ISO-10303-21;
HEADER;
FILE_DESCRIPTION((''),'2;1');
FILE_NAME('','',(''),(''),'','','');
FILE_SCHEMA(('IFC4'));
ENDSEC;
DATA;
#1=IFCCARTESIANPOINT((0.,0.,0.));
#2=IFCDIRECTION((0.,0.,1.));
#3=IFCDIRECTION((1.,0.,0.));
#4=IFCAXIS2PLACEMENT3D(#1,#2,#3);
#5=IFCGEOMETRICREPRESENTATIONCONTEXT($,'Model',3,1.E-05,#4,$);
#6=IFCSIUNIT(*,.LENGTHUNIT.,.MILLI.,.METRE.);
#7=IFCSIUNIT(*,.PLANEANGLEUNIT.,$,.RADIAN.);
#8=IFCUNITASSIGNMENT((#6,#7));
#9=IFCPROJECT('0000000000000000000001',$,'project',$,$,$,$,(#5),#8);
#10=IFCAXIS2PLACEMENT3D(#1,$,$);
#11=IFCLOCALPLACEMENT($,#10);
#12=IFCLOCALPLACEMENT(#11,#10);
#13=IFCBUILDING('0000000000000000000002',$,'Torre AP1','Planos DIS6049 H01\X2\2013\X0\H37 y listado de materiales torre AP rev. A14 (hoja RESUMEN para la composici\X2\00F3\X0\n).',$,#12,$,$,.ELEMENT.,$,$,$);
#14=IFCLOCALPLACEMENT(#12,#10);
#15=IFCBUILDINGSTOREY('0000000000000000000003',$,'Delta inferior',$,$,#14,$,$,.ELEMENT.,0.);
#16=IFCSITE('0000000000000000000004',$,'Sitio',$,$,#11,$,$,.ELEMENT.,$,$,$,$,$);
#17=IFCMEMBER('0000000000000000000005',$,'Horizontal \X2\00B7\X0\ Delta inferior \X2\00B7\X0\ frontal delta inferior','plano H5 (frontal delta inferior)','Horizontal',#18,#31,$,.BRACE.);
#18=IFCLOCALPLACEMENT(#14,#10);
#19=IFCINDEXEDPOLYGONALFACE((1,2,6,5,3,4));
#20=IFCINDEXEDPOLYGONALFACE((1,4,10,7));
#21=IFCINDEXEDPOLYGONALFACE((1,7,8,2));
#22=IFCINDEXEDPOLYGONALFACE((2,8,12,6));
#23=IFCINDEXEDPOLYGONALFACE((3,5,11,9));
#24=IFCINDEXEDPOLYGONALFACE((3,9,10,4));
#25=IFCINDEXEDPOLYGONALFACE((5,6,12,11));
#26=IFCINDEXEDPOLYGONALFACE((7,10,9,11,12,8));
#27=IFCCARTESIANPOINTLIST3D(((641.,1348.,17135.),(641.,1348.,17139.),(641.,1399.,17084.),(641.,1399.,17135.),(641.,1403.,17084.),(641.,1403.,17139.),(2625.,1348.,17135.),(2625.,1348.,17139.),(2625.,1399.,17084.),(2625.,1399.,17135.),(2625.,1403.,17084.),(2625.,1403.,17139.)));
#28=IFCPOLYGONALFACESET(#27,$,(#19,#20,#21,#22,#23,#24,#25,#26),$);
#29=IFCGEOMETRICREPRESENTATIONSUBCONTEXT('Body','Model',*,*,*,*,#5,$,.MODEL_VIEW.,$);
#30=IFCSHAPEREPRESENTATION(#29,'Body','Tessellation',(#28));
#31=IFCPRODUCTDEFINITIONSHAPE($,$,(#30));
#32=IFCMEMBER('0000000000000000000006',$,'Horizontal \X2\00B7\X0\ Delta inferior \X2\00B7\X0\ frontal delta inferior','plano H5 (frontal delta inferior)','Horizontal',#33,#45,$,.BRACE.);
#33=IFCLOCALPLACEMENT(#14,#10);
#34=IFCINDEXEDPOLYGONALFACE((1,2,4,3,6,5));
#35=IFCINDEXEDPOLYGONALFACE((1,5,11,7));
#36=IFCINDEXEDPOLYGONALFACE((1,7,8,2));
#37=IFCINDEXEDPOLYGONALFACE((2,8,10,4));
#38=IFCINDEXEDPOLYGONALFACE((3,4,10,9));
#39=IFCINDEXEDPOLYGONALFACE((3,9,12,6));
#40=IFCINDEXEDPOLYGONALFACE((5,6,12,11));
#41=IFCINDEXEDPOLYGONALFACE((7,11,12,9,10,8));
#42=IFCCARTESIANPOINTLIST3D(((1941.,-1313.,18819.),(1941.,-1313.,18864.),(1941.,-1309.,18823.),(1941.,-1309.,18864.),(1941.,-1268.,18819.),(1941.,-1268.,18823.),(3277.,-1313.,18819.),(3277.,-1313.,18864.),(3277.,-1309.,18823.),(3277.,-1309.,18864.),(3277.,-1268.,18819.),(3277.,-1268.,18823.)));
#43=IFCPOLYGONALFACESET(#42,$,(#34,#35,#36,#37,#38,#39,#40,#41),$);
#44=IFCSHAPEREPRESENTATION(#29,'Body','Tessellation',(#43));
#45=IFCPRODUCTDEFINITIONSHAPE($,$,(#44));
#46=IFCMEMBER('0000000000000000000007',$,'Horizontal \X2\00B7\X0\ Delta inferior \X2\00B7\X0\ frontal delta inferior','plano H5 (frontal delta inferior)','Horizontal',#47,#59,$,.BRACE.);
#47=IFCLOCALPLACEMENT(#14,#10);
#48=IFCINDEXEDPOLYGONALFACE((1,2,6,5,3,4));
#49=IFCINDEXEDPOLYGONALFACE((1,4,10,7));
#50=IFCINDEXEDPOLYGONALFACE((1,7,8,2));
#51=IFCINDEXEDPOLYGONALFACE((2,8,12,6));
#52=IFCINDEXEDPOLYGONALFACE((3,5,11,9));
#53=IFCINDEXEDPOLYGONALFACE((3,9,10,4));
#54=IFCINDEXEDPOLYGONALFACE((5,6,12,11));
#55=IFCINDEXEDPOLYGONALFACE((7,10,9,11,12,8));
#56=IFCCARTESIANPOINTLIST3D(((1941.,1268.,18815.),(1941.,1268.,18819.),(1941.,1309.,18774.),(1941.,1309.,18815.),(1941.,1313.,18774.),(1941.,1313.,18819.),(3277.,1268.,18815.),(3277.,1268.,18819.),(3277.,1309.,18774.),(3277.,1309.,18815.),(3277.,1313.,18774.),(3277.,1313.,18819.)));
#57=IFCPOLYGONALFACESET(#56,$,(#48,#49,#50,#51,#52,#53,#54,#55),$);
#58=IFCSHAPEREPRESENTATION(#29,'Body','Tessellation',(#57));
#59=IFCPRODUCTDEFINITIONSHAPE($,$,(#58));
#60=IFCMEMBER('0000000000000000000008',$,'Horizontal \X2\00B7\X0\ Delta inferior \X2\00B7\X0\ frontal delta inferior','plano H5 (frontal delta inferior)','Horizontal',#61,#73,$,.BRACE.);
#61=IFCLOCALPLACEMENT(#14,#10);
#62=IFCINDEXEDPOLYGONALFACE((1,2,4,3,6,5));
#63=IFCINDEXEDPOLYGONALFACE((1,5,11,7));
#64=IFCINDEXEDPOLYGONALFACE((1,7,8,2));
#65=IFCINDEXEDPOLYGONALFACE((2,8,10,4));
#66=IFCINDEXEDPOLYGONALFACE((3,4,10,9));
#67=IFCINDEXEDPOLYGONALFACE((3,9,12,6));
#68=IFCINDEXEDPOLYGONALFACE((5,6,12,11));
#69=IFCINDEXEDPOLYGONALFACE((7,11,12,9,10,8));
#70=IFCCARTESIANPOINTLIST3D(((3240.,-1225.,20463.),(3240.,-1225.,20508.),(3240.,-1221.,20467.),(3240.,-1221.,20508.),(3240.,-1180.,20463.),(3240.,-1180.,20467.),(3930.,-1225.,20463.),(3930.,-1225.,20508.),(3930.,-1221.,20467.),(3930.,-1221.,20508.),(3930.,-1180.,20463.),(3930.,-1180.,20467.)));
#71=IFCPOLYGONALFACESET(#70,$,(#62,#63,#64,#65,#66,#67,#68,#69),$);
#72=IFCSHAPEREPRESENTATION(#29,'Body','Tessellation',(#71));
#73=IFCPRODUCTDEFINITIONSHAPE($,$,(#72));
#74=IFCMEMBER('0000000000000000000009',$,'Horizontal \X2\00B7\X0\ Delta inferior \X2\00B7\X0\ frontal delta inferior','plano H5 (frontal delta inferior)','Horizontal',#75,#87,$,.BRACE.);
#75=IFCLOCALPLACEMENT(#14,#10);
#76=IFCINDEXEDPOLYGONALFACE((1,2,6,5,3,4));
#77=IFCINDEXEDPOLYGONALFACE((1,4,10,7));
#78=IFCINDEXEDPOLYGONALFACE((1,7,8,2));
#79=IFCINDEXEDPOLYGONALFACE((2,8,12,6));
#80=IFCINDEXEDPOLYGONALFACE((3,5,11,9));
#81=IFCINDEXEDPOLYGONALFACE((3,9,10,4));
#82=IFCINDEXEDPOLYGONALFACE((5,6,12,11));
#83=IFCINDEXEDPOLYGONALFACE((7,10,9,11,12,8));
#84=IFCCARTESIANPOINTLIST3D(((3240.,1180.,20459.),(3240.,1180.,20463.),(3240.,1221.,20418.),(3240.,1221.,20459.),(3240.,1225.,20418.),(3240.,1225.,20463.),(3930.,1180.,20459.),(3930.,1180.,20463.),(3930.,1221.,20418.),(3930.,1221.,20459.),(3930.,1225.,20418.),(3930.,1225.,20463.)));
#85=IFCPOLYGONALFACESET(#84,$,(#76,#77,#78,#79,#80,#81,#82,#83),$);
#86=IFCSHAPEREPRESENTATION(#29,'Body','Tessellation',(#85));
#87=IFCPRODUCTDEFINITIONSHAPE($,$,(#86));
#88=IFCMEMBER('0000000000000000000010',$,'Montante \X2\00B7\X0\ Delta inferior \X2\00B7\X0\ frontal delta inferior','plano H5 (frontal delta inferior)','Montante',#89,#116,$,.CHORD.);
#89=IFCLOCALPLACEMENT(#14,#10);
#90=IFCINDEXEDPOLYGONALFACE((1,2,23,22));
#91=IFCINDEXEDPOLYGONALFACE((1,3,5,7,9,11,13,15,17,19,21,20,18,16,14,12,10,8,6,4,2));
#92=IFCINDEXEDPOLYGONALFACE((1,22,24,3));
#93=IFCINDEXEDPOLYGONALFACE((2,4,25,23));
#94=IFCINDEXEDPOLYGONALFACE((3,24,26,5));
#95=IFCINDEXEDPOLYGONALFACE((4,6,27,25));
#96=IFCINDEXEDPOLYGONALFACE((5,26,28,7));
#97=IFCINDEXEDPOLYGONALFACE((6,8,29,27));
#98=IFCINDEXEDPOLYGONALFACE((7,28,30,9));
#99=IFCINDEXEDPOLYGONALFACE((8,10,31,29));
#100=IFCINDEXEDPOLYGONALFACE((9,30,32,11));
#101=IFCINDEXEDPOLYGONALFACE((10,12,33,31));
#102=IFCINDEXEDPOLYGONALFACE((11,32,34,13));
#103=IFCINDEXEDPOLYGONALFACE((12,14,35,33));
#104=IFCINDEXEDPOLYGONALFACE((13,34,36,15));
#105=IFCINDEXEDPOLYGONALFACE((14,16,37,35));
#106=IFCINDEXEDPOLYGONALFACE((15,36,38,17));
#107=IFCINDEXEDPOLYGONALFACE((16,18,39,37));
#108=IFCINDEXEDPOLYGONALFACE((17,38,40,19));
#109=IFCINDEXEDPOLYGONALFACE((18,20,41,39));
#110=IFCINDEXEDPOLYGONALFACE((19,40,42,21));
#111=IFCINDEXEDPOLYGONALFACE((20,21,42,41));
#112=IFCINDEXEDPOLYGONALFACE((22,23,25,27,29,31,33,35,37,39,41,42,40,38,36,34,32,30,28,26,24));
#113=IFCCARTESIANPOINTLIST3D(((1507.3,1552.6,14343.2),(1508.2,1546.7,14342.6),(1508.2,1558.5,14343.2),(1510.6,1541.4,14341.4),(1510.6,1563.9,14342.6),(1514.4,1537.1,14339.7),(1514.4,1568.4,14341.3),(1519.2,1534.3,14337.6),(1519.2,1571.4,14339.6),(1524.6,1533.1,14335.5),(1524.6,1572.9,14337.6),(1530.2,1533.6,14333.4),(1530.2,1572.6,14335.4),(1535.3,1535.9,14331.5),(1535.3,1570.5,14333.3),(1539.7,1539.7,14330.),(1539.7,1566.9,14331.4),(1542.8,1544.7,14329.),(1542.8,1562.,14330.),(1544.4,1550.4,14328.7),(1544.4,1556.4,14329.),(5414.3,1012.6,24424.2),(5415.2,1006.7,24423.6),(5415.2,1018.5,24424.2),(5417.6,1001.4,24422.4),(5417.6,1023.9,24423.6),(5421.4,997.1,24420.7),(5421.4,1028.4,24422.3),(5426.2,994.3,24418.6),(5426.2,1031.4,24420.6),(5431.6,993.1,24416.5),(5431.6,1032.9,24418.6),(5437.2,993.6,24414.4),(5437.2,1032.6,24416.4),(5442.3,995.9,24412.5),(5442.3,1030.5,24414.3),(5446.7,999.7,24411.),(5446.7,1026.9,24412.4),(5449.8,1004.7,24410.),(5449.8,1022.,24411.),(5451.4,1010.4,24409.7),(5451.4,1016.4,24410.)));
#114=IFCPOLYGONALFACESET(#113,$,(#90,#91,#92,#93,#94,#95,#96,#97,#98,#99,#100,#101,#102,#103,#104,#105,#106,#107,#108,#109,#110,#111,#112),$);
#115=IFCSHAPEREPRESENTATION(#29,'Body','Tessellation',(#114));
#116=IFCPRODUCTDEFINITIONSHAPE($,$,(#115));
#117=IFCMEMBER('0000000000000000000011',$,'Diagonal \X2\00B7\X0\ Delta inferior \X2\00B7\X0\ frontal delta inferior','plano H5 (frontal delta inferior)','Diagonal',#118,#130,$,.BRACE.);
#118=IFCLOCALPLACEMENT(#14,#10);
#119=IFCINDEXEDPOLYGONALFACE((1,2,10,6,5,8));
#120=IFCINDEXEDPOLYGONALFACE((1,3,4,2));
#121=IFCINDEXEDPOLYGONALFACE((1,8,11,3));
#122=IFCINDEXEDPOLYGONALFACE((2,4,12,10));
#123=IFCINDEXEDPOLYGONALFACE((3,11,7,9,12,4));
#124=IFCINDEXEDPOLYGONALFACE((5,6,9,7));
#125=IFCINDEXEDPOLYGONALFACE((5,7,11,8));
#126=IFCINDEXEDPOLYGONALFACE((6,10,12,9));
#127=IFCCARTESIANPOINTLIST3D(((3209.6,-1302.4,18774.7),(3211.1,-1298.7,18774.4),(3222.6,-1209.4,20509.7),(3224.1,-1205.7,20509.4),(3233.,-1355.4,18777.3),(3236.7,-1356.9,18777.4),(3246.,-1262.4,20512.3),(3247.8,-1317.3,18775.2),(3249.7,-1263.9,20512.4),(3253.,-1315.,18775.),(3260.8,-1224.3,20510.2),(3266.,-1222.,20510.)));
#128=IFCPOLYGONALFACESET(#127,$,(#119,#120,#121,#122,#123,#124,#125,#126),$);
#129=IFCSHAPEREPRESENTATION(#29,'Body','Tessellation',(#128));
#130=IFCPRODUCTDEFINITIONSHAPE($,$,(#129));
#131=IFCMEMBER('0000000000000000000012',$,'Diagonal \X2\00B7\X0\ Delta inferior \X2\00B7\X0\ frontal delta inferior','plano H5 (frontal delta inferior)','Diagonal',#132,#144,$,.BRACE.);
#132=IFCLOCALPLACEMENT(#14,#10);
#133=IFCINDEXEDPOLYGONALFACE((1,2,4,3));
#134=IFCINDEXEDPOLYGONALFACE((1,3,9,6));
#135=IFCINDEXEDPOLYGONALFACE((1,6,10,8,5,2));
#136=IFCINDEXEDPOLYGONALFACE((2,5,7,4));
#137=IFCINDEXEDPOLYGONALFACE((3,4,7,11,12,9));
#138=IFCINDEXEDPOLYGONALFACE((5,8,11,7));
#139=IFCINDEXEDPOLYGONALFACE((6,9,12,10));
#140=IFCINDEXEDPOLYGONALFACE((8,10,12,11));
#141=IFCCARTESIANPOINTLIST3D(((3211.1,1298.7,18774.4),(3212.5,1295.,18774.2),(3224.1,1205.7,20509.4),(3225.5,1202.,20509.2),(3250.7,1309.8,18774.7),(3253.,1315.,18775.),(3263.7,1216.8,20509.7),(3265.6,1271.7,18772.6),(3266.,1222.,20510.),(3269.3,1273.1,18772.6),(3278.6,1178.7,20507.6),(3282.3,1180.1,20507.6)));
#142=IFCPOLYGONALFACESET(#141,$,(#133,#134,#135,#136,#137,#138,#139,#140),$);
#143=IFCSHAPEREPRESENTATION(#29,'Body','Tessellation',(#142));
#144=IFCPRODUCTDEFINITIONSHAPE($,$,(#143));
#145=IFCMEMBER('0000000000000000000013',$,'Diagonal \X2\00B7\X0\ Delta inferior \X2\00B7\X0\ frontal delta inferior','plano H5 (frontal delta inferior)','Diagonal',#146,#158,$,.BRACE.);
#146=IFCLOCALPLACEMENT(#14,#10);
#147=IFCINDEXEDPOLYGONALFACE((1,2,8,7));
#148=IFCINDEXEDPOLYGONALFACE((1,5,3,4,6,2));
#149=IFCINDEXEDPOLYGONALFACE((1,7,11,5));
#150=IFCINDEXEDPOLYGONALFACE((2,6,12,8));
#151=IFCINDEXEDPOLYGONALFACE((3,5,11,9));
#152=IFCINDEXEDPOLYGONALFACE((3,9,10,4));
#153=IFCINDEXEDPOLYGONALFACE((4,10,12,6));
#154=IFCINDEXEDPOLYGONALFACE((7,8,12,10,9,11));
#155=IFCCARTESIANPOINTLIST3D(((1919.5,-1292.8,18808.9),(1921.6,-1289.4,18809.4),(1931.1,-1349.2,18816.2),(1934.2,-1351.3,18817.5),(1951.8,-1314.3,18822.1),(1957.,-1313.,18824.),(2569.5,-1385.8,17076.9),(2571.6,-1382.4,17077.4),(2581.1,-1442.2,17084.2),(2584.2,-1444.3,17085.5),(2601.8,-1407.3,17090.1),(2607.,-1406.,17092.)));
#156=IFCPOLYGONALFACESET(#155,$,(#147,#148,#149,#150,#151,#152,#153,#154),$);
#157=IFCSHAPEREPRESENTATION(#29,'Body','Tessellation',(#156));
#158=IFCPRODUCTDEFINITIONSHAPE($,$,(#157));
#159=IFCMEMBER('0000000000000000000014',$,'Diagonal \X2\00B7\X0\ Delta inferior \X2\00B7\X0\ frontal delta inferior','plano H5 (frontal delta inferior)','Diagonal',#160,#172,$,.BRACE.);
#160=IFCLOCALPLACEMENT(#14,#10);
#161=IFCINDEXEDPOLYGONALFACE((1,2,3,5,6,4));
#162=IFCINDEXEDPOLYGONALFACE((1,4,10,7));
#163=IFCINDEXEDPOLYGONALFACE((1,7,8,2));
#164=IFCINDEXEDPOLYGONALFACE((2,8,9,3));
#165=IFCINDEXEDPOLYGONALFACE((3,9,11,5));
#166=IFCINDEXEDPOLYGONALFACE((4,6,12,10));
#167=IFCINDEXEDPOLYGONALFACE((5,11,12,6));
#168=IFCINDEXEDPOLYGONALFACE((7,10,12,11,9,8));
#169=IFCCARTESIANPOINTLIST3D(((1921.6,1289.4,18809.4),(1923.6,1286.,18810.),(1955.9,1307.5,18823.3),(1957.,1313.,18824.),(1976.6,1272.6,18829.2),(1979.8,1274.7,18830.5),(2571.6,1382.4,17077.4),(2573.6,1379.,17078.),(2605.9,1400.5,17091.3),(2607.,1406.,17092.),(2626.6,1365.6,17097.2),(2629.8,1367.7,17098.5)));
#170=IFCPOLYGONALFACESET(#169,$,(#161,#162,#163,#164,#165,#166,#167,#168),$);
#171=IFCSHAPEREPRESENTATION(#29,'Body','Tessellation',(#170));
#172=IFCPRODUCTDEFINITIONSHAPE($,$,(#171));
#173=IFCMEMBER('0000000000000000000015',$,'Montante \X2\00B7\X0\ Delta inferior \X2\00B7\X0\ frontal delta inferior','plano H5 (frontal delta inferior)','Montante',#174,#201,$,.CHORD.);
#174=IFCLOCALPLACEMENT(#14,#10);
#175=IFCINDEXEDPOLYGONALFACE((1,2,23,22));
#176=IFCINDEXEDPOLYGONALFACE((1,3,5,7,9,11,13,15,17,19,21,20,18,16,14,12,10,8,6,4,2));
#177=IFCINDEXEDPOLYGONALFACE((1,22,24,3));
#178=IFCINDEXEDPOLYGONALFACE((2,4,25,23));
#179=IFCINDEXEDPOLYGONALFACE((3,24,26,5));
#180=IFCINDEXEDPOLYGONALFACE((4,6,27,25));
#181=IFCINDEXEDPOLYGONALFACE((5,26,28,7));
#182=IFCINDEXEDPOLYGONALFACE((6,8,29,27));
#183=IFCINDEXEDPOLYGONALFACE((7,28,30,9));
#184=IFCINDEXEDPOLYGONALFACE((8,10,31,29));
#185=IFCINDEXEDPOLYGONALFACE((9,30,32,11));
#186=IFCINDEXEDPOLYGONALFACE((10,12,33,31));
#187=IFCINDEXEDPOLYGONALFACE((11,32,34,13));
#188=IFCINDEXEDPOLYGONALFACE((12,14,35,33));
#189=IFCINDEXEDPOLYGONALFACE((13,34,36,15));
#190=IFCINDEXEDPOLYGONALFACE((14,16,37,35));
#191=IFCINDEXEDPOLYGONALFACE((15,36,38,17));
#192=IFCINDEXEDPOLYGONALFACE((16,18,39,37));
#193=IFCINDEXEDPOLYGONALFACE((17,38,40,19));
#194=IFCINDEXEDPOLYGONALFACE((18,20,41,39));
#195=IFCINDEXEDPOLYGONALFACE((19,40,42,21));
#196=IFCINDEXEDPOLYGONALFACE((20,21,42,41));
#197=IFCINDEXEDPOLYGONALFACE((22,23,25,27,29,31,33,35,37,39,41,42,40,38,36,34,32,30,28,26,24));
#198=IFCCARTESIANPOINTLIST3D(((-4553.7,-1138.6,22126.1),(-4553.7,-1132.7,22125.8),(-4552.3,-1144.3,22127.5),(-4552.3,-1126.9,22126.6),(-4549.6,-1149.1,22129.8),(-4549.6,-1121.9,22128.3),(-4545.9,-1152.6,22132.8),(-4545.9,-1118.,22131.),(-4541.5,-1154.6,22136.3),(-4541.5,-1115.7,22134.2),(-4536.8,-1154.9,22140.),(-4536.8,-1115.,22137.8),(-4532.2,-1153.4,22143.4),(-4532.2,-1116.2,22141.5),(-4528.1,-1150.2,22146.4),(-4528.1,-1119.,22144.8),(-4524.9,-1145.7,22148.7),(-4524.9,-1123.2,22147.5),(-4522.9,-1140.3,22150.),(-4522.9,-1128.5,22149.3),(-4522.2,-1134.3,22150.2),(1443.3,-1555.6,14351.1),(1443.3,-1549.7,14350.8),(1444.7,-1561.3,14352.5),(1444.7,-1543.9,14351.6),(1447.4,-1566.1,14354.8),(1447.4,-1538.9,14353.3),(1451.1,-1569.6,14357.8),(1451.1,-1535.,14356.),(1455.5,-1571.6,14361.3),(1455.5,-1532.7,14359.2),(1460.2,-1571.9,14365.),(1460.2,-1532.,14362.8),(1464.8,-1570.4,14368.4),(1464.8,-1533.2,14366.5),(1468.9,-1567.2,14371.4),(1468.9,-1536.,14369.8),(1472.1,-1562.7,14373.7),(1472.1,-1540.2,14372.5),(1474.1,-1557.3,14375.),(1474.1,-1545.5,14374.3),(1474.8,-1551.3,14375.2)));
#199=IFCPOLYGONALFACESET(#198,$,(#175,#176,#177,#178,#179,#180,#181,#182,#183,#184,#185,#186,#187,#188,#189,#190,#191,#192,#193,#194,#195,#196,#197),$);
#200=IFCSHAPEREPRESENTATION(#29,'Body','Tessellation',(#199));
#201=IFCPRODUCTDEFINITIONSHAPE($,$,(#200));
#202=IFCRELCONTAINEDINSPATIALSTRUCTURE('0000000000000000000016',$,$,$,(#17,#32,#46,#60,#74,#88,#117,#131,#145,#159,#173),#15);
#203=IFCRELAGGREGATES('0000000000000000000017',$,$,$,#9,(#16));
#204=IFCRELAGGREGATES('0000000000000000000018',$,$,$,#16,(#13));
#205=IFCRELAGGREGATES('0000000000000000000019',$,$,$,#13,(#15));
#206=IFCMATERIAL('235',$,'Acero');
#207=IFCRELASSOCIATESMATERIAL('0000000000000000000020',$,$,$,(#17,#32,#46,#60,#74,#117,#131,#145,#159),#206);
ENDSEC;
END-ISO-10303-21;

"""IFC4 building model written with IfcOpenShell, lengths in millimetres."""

from ifc_helpers import new_model, si_unit, frame, frame_2d, origin, origin_with_axes, place, context, subcontext, project, spatial, circle, l_section, extrude, material, element, save


model = new_model("IFC4")

# Units and contexts
model_context = context("Model", 3, precision=1e-05, world=origin_with_axes())
body_context = subcontext(model_context, "Body", "Model", "MODEL_VIEW")
ifc_project = project(units=[si_unit("LENGTHUNIT", "METRE", prefix="MILLI"), si_unit("PLANEANGLEUNIT", "RADIAN")], contexts=[model_context])

# Site, building, storey
site_placement = place(None, origin())
site = spatial("IfcSite", under=ifc_project, at=site_placement, Name="Sitio", CompositionType="ELEMENT")
building_placement = place(site_placement, origin())
building = spatial("IfcBuilding", under=site, at=building_placement, Name="Torre AP1", Description="Planos DIS6049 H01–H37 y listado de materiales torre AP rev. A14 (hoja RESUMEN para la composición).", CompositionType="ELEMENT")
storey_placement = place(building_placement, origin())
storey = spatial("IfcBuildingStorey", under=building, at=storey_placement, Name="Delta inferior", CompositionType="ELEMENT", Elevation=0.0)

# Members
ifc_material_1 = material(Name="235", Category="Acero")
member_1_placement = place(storey_placement, frame((641.0, 1403.0, 17139.0), z_axis=(1.0, 0.0, 0.0), x_axis=(0.0, -1.0, 0.0)))
element("IfcMember", 1, at=member_1_placement, inside=storey, material=ifc_material_1, Name="Horizontal · Delta inferior · frontal delta inferior", Description="plano H5 (frontal delta inferior)", ObjectType="Horizontal", PredefinedType="BRACE", context=body_context, shape_type="SweptSolid", body=[
    extrude(l_section(Depth=55.0, Width=55.0, Thickness=4.0, at=frame_2d((27.5, 27.5))), None, (0.0, 0.0, 1.0), 1984.0),
])
for number, where, z_axis, x_axis, name in (
    (2, (1941.0, -1313.0, 18819.0), (1.0, 0.0, 0.0), (0.0, 1.0, 0.0), "Horizontal · Delta inferior · frontal delta inferior"),
    (3, (1941.0, 1313.0, 18819.0), (1.0, 0.0, 0.0), (0.0, -1.0, 0.0), "Horizontal · Delta inferior · frontal delta inferior"),
):
    element("IfcMember", number, at=place(storey_placement, frame(where, z_axis=z_axis, x_axis=x_axis)), inside=storey, material=ifc_material_1, Name=name, Description="plano H5 (frontal delta inferior)", ObjectType="Horizontal", PredefinedType="BRACE", context=body_context, shape_type="SweptSolid", body=[
        extrude(l_section(Depth=45.0, Width=45.0, Thickness=4.0, at=frame_2d((22.5, 22.5))), None, (0.0, 0.0, 1.0), 1336.0),
    ])
for number, where, z_axis, x_axis, name in (
    (4, (3240.0, -1225.0, 20463.0), (1.0, 0.0, 0.0), (0.0, 1.0, 0.0), "Horizontal · Delta inferior · frontal delta inferior"),
    (5, (3240.0, 1225.0, 20463.0), (1.0, 0.0, 0.0), (0.0, -1.0, 0.0), "Horizontal · Delta inferior · frontal delta inferior"),
):
    element("IfcMember", number, at=place(storey_placement, frame(where, z_axis=z_axis, x_axis=x_axis)), inside=storey, material=ifc_material_1, Name=name, Description="plano H5 (frontal delta inferior)", ObjectType="Horizontal", PredefinedType="BRACE", context=body_context, shape_type="SweptSolid", body=[
        extrude(l_section(Depth=45.0, Width=45.0, Thickness=4.0, at=frame_2d((22.5, 22.5))), None, (0.0, 0.0, 1.0), 690.0),
    ])
for number, where, z_axis, x_axis, name in (
    (6, (1526.0, 1553.0, 14336.0), (0.36092, -0.049884, 0.931262), (-0.932597, -0.019305, 0.360404), "Montante · Delta inferior · frontal delta inferior"),
):
    element("IfcMember", number, at=place(storey_placement, frame(where, z_axis=z_axis, x_axis=x_axis)), inside=storey, Name=name, Description="plano H5 (frontal delta inferior)", ObjectType="Montante", PredefinedType="CHORD", context=body_context, shape_type="SweptSolid", body=[
        extrude(circle(Radius=20.0), None, (0.0, 0.0, 1.0), 10825.1),
    ])
for number, where, z_axis, x_axis, name in (
    (7, (3253.0, -1315.0, 18775.0), (0.007482, 0.053524, 0.998539), (-0.932081, 0.362036, -0.012422), "Diagonal · Delta inferior · frontal delta inferior"),
    (8, (3253.0, 1315.0, 18775.0), (0.007482, -0.053524, 0.998539), (-0.932081, -0.362036, -0.012422), "Diagonal · Delta inferior · frontal delta inferior"),
):
    element("IfcMember", number, at=place(storey_placement, frame(where, z_axis=z_axis, x_axis=x_axis)), inside=storey, material=ifc_material_1, Name=name, Description="plano H5 (frontal delta inferior)", ObjectType="Diagonal", PredefinedType="BRACE", context=body_context, shape_type="SweptSolid", body=[
        extrude(l_section(Depth=45.0, Width=45.0, Thickness=4.0, at=frame_2d((22.5, 22.5))), None, (0.0, 0.0, 1.0), 1737.5),
    ])
for number, where, z_axis, x_axis, name in (
    (9, (2607.0, -1406.0, 17092.0), (-0.350917, 0.050208, 0.935059), (-0.787637, 0.524232, -0.32374), "Diagonal · Delta inferior · frontal delta inferior"),
    (10, (2607.0, 1406.0, 17092.0), (-0.350917, -0.050208, 0.935059), (-0.787637, -0.524232, -0.32374), "Diagonal · Delta inferior · frontal delta inferior"),
):
    element("IfcMember", number, at=place(storey_placement, frame(where, z_axis=z_axis, x_axis=x_axis)), inside=storey, material=ifc_material_1, Name=name, Description="plano H5 (frontal delta inferior)", ObjectType="Diagonal", PredefinedType="BRACE", context=body_context, shape_type="SweptSolid", body=[
        extrude(l_section(Depth=45.0, Width=45.0, Thickness=4.0, at=frame_2d((22.5, 22.5))), None, (0.0, 0.0, 1.0), 1852.3),
    ])
for number, where, z_axis, x_axis, name in (
    (11, (1459.0, -1552.0, 14363.0), (-0.610199, 0.04243, 0.791111), (0.792248, 0.03268, 0.609323), "Montante · Delta inferior · frontal delta inferior"),
):
    element("IfcMember", number, at=place(storey_placement, frame(where, z_axis=z_axis, x_axis=x_axis)), inside=storey, Name=name, Description="plano H5 (frontal delta inferior)", ObjectType="Montante", PredefinedType="CHORD", context=body_context, shape_type="SweptSolid", body=[
        extrude(circle(Radius=20.0), None, (0.0, 0.0, 1.0), 9827.9),
    ])

save(model, "model.ifc")
